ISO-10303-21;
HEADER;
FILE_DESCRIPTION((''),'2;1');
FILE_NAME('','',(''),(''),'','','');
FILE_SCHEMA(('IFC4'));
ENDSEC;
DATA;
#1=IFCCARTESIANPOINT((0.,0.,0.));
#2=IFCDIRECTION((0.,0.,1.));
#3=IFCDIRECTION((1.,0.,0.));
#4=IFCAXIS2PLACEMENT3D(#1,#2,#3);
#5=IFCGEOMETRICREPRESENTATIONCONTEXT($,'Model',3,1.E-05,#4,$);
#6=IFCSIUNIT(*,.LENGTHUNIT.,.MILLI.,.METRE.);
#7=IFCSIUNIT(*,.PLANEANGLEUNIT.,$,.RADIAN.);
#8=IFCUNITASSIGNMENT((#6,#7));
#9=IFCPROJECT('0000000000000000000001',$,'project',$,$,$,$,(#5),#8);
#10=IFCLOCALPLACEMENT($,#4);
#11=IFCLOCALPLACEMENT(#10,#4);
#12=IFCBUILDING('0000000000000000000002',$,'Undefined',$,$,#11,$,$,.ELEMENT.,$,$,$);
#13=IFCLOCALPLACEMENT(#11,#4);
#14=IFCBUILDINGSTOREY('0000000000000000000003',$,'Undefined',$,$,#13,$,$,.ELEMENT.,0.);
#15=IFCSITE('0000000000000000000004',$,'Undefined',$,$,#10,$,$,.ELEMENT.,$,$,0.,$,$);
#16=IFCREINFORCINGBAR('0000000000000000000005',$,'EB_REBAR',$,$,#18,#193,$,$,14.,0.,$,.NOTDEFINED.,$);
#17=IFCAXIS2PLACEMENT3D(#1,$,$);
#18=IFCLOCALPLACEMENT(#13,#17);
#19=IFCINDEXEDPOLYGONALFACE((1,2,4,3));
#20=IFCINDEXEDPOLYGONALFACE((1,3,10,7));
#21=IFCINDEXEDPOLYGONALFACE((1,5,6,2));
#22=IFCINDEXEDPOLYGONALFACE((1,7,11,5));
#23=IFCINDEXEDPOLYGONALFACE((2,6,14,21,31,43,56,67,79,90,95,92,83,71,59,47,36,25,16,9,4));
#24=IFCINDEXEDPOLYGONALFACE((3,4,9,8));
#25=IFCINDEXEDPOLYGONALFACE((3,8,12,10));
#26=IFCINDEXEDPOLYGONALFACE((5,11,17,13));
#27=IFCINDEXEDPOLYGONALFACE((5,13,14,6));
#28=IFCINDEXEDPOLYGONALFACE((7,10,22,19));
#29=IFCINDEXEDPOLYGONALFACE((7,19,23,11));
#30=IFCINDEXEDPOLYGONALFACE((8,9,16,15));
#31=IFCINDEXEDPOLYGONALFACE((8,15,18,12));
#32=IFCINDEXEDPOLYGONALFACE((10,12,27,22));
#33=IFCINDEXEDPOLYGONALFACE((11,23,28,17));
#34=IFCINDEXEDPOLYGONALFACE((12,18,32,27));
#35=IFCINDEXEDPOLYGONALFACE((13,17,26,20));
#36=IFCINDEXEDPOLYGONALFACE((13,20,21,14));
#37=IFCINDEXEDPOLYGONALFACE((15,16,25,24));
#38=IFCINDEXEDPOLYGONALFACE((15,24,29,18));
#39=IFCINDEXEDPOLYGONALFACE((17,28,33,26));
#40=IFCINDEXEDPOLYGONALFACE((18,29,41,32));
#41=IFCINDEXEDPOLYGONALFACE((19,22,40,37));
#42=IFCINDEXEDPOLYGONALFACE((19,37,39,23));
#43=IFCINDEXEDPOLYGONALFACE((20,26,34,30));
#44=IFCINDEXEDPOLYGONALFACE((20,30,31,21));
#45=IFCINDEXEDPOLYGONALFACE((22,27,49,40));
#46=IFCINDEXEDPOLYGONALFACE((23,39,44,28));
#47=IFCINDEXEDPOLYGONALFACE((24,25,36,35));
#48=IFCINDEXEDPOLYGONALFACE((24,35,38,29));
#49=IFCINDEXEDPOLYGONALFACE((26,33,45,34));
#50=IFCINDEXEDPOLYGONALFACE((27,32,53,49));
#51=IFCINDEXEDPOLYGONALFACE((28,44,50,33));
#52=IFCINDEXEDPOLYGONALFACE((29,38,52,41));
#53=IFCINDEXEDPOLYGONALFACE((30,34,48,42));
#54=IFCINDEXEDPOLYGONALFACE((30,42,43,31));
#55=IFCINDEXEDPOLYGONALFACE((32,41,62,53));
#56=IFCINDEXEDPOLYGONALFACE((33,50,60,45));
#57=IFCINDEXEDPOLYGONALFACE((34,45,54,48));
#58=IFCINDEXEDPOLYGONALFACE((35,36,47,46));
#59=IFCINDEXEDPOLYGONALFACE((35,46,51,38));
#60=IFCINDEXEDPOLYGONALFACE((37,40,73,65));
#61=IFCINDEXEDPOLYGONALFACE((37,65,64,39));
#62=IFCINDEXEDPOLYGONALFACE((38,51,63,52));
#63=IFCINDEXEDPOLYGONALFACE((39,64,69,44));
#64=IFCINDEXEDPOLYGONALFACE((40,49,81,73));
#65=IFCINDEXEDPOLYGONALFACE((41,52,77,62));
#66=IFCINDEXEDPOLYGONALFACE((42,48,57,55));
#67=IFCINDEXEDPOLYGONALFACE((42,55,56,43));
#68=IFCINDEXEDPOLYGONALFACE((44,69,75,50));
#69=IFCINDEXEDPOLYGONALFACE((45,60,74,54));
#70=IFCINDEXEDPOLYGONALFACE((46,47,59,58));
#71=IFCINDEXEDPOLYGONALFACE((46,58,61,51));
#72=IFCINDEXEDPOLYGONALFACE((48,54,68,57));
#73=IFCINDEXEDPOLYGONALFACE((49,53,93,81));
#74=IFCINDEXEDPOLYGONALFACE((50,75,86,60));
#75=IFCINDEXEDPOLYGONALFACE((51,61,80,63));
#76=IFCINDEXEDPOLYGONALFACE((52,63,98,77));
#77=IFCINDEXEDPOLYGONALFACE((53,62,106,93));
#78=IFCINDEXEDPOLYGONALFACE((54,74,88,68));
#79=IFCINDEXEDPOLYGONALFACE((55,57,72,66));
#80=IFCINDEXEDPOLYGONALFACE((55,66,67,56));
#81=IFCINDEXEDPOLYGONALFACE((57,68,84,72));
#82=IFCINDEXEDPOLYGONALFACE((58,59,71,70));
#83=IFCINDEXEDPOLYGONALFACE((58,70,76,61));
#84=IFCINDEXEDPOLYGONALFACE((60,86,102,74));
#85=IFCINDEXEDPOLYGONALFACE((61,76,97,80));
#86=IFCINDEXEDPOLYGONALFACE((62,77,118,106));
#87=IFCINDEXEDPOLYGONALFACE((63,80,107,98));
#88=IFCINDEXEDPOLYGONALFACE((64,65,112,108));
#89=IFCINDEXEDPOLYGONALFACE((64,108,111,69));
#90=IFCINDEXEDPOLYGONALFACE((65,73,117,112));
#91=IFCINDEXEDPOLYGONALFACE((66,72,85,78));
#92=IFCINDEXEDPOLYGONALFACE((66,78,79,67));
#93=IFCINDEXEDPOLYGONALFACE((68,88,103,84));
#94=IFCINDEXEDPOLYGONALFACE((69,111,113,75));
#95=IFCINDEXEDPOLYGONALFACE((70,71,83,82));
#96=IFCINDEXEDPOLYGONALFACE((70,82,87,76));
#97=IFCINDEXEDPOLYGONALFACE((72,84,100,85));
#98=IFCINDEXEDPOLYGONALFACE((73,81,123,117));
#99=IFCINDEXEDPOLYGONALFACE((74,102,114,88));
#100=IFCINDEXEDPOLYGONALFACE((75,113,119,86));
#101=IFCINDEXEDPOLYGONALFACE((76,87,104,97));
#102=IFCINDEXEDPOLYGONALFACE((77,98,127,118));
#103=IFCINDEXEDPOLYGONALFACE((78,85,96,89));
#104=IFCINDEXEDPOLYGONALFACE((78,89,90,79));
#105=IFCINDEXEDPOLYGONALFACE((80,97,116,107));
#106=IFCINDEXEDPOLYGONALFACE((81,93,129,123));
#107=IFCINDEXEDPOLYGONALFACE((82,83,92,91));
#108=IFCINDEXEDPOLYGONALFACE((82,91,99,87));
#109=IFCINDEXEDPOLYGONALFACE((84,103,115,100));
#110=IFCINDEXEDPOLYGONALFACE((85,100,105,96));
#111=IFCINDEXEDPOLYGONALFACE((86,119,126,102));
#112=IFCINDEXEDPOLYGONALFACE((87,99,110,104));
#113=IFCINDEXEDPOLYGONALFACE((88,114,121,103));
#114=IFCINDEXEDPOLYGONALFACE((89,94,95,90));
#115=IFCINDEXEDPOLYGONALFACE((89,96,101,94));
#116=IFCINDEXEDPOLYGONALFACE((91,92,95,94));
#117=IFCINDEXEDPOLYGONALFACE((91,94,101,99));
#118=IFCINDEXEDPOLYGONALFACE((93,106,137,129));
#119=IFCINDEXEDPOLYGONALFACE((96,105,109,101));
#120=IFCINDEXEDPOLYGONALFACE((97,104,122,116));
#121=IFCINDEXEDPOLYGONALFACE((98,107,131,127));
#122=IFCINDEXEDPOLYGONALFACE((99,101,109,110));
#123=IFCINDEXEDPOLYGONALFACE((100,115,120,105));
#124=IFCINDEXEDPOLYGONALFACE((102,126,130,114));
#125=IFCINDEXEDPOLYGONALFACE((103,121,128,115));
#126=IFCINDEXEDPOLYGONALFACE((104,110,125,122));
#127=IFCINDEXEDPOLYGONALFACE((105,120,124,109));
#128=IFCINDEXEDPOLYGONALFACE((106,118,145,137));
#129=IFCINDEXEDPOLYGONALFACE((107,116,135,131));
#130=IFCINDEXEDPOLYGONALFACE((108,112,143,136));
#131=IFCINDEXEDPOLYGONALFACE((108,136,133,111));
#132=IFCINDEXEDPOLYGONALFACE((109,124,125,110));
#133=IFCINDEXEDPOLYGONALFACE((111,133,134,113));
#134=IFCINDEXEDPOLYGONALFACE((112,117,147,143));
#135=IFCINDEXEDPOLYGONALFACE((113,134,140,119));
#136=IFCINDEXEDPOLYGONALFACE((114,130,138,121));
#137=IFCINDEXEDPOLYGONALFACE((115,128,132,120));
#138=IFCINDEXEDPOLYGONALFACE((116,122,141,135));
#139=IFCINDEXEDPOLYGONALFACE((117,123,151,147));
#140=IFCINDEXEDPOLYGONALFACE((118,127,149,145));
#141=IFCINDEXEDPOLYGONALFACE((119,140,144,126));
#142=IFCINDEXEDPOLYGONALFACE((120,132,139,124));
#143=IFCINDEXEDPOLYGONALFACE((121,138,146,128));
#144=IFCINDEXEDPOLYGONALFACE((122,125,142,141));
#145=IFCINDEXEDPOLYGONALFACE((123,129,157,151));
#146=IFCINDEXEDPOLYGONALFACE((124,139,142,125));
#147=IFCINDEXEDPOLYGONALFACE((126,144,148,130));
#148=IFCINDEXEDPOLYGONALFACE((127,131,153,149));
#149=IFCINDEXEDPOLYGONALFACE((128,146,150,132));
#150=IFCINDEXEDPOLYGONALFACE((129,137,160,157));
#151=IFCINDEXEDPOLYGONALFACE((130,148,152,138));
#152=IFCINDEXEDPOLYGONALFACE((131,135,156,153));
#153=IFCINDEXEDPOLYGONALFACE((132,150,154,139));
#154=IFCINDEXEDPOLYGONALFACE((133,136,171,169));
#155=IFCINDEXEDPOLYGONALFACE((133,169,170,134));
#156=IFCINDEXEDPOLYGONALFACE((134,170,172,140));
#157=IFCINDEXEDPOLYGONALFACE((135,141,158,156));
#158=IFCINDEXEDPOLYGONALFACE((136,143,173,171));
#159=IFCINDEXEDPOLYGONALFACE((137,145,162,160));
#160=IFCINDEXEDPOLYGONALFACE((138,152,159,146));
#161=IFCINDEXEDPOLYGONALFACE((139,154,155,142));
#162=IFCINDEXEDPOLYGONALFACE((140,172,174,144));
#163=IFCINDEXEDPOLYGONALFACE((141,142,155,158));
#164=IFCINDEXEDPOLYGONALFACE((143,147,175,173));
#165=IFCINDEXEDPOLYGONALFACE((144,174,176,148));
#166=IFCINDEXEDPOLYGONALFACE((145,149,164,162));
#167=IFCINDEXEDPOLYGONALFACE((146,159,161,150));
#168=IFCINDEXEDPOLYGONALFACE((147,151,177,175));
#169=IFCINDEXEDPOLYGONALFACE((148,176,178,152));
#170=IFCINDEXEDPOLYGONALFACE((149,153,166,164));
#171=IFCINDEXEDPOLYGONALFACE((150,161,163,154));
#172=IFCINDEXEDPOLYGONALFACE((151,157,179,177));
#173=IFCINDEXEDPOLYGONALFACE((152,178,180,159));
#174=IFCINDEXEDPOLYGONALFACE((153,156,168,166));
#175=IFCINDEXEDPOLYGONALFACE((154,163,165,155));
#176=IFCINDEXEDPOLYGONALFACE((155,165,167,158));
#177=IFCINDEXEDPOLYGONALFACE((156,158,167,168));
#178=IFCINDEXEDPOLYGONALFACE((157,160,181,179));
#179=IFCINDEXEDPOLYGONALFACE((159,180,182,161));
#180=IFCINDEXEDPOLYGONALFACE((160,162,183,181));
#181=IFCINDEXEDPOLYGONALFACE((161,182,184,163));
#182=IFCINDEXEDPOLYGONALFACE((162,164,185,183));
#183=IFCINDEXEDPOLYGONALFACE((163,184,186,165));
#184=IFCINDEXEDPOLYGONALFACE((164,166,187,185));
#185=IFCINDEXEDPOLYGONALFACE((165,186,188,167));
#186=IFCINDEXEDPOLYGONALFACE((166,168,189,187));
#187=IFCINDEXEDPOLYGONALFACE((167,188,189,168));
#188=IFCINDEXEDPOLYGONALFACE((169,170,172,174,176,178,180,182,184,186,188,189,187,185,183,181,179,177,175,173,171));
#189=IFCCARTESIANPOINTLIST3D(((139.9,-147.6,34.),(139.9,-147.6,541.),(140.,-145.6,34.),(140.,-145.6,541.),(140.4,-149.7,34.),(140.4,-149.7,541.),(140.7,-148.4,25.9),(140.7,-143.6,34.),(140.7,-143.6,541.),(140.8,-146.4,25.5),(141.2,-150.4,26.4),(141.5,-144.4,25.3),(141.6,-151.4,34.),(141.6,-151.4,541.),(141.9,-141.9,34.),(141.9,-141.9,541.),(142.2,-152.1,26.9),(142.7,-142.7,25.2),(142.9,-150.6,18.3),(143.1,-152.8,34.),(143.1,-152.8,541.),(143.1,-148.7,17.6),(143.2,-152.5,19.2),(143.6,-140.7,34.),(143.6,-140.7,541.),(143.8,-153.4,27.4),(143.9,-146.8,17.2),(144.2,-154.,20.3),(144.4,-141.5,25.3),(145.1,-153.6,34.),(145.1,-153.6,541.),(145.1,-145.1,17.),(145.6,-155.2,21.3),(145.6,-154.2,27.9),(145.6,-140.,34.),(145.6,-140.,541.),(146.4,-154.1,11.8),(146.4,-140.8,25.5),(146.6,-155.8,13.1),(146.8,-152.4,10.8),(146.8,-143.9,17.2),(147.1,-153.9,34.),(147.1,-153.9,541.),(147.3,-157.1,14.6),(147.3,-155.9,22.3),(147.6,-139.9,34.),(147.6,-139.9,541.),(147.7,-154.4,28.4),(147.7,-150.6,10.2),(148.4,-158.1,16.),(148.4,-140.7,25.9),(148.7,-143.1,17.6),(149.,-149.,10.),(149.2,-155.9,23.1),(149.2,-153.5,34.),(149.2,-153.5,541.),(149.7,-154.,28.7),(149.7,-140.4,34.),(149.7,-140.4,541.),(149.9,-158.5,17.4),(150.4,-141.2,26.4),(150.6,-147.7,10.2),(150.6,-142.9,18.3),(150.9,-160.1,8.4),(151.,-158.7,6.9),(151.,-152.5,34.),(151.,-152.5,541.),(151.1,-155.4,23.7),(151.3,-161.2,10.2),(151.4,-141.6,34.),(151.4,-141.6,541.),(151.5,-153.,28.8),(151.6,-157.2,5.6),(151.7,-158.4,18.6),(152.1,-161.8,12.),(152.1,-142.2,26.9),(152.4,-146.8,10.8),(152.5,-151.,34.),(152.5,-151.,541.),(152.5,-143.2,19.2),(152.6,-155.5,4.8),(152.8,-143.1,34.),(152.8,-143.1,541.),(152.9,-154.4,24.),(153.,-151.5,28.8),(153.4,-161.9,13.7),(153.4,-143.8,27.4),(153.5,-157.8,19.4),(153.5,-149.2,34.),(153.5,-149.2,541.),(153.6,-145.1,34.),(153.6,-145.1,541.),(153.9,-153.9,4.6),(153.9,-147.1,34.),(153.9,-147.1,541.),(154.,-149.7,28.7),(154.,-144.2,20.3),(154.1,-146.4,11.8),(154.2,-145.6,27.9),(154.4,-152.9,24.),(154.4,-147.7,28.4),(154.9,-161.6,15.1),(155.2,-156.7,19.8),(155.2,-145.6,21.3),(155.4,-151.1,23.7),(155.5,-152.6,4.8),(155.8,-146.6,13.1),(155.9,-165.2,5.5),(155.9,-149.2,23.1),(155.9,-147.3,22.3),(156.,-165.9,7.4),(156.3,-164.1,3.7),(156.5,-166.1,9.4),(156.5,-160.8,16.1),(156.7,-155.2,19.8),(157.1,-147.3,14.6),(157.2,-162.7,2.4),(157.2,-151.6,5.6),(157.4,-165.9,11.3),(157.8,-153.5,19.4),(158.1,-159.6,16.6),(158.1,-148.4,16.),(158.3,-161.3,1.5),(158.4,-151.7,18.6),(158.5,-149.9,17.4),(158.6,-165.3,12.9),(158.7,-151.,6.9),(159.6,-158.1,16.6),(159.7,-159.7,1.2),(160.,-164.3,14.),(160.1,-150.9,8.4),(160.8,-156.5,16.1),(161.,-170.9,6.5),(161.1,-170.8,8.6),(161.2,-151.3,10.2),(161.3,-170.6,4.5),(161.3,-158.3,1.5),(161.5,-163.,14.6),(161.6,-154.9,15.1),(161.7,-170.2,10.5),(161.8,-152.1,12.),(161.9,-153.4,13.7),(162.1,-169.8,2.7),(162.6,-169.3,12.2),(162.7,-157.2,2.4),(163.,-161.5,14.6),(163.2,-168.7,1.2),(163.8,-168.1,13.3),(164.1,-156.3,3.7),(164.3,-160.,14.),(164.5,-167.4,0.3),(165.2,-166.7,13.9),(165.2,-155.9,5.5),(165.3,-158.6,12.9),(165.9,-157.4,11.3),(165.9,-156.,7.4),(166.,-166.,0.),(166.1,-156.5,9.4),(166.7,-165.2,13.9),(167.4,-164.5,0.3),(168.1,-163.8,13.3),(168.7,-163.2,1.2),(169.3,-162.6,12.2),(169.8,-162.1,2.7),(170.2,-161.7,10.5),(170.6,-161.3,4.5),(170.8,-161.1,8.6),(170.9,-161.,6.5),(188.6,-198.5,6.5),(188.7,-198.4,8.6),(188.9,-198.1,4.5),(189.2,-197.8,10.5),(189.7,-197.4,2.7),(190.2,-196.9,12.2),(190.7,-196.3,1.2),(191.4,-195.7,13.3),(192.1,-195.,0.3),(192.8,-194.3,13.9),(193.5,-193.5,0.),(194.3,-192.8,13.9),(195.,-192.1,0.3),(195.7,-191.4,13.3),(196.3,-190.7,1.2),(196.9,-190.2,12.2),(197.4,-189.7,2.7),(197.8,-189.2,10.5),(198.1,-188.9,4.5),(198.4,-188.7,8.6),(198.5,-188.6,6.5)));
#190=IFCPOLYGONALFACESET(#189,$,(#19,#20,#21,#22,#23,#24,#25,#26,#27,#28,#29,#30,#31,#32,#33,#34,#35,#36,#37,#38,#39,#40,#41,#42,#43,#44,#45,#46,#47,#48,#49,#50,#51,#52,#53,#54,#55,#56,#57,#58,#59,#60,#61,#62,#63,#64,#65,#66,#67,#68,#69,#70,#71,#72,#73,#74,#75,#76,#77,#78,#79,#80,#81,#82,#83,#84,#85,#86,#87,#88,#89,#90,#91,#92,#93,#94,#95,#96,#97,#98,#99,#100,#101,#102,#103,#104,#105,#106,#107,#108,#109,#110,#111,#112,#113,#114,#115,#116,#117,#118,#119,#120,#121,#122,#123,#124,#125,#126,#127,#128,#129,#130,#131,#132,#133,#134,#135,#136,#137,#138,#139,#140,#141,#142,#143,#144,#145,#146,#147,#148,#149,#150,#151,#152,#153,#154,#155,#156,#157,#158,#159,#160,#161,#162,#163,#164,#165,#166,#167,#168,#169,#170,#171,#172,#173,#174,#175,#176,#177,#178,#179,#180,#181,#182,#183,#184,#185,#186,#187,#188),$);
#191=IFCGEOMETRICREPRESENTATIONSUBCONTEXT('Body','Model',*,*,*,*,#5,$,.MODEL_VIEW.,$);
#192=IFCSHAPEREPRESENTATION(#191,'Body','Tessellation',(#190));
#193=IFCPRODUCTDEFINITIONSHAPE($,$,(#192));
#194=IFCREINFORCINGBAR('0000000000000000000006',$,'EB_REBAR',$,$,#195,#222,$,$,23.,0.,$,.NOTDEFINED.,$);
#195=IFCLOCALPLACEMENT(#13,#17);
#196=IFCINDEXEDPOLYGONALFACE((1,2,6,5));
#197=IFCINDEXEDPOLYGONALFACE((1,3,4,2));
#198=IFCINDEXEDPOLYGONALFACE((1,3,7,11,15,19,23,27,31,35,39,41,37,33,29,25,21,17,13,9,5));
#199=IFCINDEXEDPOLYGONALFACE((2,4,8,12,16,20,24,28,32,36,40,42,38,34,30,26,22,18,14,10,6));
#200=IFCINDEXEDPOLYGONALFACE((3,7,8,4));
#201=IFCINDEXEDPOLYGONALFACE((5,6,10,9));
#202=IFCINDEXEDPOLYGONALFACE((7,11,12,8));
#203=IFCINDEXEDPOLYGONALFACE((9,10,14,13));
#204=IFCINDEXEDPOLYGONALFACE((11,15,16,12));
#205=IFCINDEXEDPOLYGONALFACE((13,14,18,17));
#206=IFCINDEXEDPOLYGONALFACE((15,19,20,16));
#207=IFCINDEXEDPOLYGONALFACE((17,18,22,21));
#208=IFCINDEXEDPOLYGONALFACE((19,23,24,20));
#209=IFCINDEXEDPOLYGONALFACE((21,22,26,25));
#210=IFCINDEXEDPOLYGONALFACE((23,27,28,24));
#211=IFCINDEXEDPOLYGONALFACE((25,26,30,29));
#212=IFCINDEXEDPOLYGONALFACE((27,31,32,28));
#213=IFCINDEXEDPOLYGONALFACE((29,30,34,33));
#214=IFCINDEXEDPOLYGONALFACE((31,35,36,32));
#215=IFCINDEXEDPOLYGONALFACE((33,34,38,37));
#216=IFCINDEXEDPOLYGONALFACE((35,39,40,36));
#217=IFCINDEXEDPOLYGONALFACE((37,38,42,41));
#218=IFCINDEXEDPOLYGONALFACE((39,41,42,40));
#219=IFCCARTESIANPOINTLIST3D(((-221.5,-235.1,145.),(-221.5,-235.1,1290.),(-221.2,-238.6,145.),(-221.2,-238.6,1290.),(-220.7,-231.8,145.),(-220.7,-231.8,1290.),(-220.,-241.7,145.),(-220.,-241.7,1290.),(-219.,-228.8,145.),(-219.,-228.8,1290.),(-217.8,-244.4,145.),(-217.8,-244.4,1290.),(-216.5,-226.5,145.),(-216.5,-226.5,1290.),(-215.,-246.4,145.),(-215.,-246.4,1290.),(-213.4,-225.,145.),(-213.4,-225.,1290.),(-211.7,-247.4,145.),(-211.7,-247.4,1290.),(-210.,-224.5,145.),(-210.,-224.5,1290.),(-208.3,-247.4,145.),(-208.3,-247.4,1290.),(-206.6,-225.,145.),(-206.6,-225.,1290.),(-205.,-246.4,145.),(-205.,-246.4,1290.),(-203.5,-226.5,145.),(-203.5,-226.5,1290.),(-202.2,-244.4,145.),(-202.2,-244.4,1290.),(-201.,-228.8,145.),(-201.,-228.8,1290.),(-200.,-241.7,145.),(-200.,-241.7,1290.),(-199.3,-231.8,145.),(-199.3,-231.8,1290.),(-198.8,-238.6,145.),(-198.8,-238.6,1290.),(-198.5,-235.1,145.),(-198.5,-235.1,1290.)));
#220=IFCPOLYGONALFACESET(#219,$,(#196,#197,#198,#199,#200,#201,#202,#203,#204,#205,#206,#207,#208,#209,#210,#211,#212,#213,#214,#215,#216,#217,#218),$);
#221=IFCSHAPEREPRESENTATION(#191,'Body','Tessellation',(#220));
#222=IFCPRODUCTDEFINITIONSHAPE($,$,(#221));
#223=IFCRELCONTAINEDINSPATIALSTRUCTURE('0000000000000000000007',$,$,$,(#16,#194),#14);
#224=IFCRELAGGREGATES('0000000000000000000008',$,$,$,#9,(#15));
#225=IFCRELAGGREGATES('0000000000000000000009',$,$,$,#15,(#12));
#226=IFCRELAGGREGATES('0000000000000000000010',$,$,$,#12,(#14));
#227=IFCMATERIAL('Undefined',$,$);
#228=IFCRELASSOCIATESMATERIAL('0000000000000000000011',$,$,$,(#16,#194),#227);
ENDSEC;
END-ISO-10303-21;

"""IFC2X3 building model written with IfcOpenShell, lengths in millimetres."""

from ifc_helpers import new_model, entity, si_unit, frame, origin_with_axes, place, context, subcontext, project, spatial, source, transform, mapped, material, element, save


model = new_model("IFC2X3")

# Units and contexts
model_context = context("Model", 3, precision=1e-05, world=origin_with_axes())
body_context = subcontext(model_context, "Body", "Model", "MODEL_VIEW")
ifc_project = project(units=[si_unit("LENGTHUNIT", "METRE", prefix="MILLI"), si_unit("PLANEANGLEUNIT", "RADIAN")], contexts=[model_context])

# Site, building, storey
site_placement = place(None, origin_with_axes())
site = spatial("IfcSite", under=ifc_project, at=site_placement, Name="Undefined", CompositionType="ELEMENT", RefElevation=0.0)
building_placement = place(site_placement, origin_with_axes())
building = spatial("IfcBuilding", under=site, at=building_placement, Name="Undefined", CompositionType="ELEMENT")
storey_placement = place(building_placement, origin_with_axes())
storey = spatial("IfcBuildingStorey", under=building, at=storey_placement, Name="Undefined", CompositionType="ELEMENT", Elevation=0.0)

# Reinforcing bars
ifc_material_1 = material(Name="Undefined")
shared_shape_1 = source(origin_with_axes(), body_context, "Body", "AdvancedSweptSolid", [
    entity("IfcSweptDiskSolid", entity("IfcCompositeCurve", [entity("IfcCompositeCurveSegment", "CONTINUOUS", True, entity("IfcTrimmedCurve", entity("IfcLine", entity("IfcCartesianPoint", [0.0, 0.0, 0.0]), entity("IfcVector", entity("IfcDirection", [0.0, 0.0, -1.0]), 1.0)), [entity("IfcParameterValue", 0.0)], [entity("IfcParameterValue", 39.002617)], True, "PARAMETER")), entity("IfcCompositeCurveSegment", "CONTINUOUS", True, entity("IfcTrimmedCurve", entity("IfcCircle", entity("IfcAxis2Placement3D", entity("IfcCartesianPoint", [27.0, 0.0, -39.0]), entity("IfcDirection", [0.0, -1.0, 0.0]), entity("IfcDirection", [-1.0, 0.0, 0.0])), 27.0), [entity("IfcParameterValue", 0.0)], [entity("IfcParameterValue", 1.570797)], True, "PARAMETER")), entity("IfcCompositeCurveSegment", "DISCONTINUOUS", True, entity("IfcTrimmedCurve", entity("IfcLine", entity("IfcCartesianPoint", [27.0, 0.0, -66.0]), entity("IfcVector", entity("IfcDirection", [1.0, 0.0, 0.0]), 1.0)), [entity("IfcParameterValue", 0.0)], [entity("IfcParameterValue", 506.999983)], True, "PARAMETER"))], False), 7.0, None, 0.0, 547.6),
])
reinforcing_bar_1_placement = place(storey_placement, frame((155.9, -155.9, 7.0), z_axis=(0.707107, -0.707107, 0.000001), x_axis=(-0.000001, 0.000001, 1.0)))
element("IfcReinforcingBar", 1, at=reinforcing_bar_1_placement, inside=storey, material=ifc_material_1, Name="EB_REBAR", BarRole="NOTDEFINED", CrossSectionArea=0.0, NominalDiameter=14.0, context=body_context, shape_type="MappedRepresentation", body=[
    mapped(shared_shape_1, transform((0.0, 0.0, 53.2))),
])
shared_shape_2 = source(origin_with_axes(), body_context, "Body", "AdvancedSweptSolid", [
    entity("IfcSweptDiskSolid", entity("IfcTrimmedCurve", entity("IfcLine", entity("IfcCartesianPoint", [0.0, 0.0, 0.0]), entity("IfcVector", entity("IfcDirection", [1.0, 0.0, 0.0]), 1.0)), [entity("IfcParameterValue", 0.0)], [entity("IfcParameterValue", 1144.999881)], True, "PARAMETER"), 11.5, None, 0.0, 1145.0),
])
reinforcing_bar_2_placement = place(storey_placement, frame((-210.0, -236.0, 145.0), z_axis=(0.0, 1.0, 0.0), x_axis=(0.0, 0.0, 1.0)))
element("IfcReinforcingBar", 2, at=reinforcing_bar_2_placement, inside=storey, material=ifc_material_1, Name="EB_REBAR", BarRole="NOTDEFINED", CrossSectionArea=0.0, NominalDiameter=23.0, context=body_context, shape_type="MappedRepresentation", body=[
    mapped(shared_shape_2, transform((0.0, 0.0, 0.0))),
])

save(model, "model.ifc")
